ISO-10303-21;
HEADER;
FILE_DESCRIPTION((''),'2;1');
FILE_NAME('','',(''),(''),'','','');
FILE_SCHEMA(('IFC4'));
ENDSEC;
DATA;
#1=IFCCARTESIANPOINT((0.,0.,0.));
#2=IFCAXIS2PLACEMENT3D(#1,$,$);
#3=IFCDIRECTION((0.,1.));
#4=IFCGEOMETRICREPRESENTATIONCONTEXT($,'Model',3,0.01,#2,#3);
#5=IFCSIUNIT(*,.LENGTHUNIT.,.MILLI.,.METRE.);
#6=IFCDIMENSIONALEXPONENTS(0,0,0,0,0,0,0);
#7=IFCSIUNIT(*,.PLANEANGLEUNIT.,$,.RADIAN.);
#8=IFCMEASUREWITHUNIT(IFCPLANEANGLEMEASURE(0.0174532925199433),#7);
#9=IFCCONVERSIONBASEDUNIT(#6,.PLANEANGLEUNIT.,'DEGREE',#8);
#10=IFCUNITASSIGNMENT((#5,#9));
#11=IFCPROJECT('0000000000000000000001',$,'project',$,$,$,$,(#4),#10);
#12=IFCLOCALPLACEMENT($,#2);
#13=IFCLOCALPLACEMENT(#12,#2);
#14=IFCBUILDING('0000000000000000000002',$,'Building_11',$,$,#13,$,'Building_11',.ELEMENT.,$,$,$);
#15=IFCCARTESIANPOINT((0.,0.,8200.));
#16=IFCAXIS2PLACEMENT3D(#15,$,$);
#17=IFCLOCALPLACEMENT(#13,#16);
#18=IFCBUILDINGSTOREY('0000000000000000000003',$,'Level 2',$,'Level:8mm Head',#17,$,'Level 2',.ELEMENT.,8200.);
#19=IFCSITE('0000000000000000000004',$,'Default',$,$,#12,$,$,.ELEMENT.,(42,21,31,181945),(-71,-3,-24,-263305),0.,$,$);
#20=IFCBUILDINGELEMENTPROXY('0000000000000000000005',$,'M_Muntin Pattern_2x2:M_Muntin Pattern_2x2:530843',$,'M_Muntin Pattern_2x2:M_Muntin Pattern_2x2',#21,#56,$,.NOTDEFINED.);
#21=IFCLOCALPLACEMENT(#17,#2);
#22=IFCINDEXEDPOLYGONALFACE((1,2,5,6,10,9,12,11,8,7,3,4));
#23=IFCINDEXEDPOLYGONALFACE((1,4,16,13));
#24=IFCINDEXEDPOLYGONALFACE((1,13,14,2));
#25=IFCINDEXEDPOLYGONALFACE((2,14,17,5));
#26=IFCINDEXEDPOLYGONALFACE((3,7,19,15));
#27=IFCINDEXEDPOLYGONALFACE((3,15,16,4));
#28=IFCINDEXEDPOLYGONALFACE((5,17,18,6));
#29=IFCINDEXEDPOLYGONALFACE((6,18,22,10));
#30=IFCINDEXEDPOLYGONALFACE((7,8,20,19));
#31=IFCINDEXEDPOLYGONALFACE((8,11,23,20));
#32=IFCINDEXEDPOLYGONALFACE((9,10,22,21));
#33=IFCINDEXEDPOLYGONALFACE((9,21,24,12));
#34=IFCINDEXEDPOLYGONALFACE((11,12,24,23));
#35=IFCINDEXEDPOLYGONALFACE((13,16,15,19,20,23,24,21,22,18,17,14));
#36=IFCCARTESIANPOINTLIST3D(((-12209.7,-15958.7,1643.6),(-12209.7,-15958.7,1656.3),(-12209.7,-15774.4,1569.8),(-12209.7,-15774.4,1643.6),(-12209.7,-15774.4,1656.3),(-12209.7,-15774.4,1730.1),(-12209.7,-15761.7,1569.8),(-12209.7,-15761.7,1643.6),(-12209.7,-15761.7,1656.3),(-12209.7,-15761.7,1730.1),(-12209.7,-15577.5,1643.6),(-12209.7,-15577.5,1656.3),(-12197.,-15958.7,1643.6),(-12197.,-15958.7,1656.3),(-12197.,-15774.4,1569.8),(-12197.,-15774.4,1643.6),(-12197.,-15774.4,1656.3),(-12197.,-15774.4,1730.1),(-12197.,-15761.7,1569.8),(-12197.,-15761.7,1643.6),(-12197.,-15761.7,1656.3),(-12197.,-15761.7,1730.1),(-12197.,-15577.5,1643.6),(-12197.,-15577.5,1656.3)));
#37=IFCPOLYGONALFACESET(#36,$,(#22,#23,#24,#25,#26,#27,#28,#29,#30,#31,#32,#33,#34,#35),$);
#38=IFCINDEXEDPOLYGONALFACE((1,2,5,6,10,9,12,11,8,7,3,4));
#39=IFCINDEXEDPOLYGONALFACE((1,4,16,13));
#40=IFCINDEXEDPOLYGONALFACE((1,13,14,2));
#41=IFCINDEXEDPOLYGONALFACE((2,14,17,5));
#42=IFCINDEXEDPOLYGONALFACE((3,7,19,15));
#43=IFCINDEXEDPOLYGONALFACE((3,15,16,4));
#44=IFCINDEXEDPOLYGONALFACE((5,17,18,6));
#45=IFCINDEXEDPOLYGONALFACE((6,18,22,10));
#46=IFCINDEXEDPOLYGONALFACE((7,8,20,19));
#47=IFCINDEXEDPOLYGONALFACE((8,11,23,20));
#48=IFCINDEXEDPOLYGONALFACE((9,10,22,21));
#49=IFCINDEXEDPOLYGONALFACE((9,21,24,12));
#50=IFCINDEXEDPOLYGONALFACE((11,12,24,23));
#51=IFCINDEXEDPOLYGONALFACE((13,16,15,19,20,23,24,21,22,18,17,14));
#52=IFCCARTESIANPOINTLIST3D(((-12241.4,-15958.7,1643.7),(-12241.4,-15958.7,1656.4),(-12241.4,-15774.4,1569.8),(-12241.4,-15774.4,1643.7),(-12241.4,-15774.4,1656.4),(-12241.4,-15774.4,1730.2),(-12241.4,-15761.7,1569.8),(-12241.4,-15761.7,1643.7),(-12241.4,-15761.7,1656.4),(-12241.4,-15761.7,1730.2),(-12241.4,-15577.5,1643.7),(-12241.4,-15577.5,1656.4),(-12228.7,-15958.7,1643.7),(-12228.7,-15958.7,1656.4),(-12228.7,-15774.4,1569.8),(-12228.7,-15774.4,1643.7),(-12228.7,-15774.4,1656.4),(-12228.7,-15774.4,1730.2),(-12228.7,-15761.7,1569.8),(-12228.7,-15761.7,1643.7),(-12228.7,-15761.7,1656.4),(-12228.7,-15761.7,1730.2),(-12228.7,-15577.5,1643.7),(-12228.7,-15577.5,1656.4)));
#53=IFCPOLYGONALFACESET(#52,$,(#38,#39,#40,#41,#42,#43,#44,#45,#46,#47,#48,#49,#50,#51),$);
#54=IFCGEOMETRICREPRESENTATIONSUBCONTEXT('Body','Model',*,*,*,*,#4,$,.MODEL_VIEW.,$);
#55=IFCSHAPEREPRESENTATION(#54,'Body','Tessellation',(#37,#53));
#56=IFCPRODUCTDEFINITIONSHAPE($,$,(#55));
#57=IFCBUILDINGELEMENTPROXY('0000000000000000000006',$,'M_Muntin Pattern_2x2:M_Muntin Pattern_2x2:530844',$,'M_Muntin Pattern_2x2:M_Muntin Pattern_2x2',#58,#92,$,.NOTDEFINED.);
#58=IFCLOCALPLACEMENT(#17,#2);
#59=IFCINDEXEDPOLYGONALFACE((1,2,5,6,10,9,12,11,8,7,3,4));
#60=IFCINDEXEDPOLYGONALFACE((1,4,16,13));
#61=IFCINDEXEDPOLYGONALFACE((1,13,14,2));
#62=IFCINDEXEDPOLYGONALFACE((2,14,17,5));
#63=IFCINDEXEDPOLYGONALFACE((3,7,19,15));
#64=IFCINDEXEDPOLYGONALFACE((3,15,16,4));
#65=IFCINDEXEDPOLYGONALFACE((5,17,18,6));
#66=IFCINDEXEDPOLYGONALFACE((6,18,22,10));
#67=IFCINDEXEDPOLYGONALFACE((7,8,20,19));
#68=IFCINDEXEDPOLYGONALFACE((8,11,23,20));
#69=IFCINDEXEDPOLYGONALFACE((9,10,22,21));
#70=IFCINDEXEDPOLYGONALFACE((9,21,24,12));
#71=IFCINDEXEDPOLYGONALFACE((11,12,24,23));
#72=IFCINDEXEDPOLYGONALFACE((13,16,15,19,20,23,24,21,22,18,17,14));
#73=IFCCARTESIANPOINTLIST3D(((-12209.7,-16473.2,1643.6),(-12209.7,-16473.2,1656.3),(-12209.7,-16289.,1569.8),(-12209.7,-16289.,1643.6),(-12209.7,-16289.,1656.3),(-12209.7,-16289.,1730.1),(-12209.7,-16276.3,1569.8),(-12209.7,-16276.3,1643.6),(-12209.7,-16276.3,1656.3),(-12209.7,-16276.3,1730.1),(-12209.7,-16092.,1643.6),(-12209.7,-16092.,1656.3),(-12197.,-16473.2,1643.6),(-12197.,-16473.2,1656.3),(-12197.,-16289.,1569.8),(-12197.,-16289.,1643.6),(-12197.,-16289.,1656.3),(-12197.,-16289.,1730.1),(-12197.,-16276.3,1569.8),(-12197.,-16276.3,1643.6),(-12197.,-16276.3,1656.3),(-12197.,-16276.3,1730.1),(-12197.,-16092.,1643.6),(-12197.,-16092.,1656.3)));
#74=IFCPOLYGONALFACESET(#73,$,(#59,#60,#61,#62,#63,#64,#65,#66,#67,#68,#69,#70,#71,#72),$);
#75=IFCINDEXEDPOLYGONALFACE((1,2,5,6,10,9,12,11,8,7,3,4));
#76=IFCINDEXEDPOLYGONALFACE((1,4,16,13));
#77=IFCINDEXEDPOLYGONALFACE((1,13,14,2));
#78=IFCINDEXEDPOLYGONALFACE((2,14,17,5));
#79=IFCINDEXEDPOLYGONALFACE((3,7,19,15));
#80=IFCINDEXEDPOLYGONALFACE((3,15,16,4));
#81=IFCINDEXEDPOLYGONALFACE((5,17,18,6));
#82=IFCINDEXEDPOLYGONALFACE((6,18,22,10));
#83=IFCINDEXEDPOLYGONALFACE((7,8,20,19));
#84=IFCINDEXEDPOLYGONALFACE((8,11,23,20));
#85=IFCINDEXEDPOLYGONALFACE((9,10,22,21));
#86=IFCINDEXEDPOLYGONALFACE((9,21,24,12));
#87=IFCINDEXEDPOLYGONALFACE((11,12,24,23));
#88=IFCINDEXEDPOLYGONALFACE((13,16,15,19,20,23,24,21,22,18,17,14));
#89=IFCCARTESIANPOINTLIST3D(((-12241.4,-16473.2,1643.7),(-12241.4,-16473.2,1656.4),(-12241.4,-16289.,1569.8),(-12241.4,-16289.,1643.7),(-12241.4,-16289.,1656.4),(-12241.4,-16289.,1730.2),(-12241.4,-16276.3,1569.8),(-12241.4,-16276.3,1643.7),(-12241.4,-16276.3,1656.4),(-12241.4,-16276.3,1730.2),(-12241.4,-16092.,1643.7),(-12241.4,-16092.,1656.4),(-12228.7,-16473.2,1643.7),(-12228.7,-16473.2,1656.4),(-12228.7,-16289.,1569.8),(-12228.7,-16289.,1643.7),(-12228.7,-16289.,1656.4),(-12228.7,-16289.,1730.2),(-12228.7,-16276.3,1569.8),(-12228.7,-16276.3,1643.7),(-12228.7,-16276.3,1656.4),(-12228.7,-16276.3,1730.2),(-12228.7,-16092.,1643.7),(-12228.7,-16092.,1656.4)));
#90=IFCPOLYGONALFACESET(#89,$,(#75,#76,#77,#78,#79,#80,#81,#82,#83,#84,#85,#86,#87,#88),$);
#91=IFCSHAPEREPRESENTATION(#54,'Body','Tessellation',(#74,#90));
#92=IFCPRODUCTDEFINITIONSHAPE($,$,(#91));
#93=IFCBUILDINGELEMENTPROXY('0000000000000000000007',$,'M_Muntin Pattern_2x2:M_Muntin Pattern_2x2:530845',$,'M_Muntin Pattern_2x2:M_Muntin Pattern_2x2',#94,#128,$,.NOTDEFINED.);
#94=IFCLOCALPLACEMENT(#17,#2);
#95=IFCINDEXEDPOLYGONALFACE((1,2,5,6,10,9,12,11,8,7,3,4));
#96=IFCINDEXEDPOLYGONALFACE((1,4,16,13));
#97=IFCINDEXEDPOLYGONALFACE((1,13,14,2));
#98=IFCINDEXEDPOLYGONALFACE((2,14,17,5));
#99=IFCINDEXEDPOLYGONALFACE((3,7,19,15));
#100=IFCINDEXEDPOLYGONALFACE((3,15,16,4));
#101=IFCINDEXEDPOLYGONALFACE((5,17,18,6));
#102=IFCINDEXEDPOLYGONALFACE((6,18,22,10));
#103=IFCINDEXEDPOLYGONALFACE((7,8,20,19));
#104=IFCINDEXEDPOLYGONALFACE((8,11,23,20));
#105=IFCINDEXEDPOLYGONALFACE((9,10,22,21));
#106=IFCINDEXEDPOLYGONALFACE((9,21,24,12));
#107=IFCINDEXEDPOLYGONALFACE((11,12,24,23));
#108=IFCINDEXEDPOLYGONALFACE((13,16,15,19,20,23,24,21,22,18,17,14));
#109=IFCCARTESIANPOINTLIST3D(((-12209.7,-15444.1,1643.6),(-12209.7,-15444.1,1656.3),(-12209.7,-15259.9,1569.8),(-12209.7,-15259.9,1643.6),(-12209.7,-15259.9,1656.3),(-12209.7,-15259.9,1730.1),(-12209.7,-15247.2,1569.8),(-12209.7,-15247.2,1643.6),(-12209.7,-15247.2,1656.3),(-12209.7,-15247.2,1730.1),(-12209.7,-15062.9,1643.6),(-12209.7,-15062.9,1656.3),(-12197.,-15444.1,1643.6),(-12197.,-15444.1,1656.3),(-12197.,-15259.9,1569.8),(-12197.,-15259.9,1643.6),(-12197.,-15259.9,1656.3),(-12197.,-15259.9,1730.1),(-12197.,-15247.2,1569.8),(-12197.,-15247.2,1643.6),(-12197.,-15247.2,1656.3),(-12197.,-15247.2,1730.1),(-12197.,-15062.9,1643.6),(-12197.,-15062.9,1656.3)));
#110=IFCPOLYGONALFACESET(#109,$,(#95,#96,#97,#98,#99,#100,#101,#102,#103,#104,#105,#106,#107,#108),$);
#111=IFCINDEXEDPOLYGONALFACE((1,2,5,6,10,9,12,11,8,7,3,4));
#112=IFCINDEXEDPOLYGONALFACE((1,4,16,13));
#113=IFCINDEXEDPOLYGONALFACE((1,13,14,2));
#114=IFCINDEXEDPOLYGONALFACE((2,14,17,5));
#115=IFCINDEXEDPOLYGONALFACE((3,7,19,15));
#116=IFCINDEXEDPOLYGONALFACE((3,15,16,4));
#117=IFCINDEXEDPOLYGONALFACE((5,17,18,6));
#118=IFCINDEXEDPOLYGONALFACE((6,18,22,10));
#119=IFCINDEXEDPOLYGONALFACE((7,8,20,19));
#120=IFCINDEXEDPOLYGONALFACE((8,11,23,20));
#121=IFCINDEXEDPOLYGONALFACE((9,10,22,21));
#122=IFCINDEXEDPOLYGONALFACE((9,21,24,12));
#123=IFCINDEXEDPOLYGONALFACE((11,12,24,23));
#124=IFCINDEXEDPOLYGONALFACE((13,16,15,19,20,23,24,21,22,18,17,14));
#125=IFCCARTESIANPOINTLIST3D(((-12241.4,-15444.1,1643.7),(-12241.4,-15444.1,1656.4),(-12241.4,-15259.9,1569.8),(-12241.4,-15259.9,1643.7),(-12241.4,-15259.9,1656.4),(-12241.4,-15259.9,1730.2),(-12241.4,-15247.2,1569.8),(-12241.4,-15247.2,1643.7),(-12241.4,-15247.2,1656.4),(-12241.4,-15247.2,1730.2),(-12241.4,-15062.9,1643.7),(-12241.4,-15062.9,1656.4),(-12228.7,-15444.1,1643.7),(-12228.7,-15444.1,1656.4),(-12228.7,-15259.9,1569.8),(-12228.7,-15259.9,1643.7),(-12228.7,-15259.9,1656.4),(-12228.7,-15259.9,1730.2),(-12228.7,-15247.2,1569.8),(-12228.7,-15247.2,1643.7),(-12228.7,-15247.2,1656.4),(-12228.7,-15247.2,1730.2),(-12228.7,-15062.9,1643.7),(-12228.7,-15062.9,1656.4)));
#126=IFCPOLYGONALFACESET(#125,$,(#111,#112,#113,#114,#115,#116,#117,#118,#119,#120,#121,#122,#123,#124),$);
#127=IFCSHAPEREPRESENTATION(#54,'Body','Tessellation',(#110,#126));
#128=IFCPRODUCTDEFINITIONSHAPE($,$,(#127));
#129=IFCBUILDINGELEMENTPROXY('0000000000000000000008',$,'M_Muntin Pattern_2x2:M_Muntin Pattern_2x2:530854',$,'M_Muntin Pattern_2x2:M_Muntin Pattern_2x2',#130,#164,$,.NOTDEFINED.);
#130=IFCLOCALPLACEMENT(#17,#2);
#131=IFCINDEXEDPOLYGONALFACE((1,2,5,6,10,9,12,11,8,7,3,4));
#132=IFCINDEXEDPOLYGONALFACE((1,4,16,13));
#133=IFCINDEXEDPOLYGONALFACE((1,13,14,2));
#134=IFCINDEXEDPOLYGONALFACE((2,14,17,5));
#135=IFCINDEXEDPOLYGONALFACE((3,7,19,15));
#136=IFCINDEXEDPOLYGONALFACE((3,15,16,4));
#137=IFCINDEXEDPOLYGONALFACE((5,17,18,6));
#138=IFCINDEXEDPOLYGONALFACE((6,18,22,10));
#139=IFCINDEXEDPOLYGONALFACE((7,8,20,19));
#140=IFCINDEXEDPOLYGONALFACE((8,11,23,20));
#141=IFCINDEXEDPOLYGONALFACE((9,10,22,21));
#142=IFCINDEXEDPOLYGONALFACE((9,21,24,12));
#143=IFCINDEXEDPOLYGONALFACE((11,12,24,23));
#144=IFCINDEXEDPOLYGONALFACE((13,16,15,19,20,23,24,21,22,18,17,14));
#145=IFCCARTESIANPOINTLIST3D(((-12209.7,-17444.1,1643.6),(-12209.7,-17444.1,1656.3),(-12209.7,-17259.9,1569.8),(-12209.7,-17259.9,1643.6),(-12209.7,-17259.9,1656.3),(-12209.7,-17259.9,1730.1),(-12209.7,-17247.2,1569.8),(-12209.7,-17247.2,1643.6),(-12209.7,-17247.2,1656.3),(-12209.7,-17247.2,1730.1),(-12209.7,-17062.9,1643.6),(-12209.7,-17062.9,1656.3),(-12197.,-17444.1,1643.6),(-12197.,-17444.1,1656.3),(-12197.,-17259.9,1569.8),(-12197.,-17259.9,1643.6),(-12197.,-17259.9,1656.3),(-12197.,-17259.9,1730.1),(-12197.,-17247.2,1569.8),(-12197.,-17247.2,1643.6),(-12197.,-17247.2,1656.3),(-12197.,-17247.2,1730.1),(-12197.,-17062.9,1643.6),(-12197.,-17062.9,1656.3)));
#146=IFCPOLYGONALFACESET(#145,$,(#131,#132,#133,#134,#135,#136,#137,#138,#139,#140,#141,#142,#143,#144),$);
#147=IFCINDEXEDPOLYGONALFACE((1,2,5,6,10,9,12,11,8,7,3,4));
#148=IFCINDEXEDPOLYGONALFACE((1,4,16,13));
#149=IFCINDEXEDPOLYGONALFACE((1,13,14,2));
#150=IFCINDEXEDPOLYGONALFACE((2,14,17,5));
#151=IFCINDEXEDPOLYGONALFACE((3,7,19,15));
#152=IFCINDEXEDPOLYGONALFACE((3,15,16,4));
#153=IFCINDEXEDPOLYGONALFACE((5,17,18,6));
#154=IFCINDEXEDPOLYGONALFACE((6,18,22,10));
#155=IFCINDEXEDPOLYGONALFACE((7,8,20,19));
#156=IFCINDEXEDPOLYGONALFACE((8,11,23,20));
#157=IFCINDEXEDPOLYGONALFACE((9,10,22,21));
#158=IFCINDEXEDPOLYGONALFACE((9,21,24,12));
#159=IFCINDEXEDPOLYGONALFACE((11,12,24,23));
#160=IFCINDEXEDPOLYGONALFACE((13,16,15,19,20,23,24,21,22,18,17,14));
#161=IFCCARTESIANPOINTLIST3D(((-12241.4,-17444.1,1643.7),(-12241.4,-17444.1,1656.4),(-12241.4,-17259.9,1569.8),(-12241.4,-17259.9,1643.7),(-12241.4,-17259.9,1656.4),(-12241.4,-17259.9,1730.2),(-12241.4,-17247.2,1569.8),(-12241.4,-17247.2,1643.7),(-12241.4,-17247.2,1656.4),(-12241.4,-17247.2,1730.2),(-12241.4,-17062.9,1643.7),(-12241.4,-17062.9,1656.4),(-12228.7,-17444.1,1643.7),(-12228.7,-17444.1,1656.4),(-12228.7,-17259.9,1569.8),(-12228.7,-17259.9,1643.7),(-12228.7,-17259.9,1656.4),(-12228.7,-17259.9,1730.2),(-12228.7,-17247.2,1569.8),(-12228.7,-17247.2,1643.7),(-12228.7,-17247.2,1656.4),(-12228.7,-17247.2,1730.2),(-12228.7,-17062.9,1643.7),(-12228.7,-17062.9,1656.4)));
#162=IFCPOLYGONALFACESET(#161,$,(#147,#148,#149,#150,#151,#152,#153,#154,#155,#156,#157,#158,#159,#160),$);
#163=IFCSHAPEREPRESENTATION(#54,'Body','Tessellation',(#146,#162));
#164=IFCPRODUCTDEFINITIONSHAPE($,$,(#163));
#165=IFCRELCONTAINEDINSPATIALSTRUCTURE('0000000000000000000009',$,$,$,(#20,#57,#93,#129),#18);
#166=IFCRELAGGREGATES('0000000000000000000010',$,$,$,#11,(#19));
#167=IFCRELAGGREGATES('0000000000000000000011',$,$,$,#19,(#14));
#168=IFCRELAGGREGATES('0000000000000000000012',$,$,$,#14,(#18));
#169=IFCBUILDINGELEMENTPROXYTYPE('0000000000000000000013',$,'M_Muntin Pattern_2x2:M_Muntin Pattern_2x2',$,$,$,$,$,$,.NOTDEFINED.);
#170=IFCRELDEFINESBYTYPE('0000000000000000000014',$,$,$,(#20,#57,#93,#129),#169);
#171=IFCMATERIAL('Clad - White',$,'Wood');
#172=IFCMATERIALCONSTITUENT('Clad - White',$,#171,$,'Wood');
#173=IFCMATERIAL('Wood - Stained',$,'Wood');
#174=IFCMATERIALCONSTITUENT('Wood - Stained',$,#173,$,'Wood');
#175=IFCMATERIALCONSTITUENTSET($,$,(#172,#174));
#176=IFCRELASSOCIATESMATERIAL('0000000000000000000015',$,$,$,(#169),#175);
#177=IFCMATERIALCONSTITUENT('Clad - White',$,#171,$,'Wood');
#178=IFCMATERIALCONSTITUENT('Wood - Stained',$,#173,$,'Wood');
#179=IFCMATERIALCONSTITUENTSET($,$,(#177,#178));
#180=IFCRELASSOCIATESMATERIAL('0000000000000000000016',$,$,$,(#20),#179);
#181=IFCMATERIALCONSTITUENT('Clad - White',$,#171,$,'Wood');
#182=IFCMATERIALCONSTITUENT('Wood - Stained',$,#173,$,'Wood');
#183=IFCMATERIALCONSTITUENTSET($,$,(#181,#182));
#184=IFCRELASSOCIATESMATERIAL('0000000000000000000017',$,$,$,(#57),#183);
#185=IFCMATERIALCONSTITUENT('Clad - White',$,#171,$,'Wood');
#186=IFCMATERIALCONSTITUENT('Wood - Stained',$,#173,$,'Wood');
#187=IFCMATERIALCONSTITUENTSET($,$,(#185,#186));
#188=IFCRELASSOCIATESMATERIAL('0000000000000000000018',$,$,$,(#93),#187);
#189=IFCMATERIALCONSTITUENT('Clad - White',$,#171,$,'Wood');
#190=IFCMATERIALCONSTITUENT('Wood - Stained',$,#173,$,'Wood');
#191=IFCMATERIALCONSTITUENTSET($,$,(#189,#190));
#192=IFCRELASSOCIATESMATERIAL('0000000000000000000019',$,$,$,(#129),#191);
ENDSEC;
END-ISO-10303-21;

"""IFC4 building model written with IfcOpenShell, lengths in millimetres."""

from ifc_helpers import new_model, entity, si_unit, converted_unit, direction, frame, origin, place, context, subcontext, project, spatial, indexed_curve, outline, extrude, source, transform, mapped, material, constituent, constituent_set, type_object, type_shapes, element, save


model = new_model("IFC4")

# Units and contexts
model_context = context("Model", 3, precision=0.01, world=origin(), true_north=direction((0.0, 1.0)))
body_context = subcontext(model_context, "Body", "Model", "MODEL_VIEW")
ifc_project = project(units=[si_unit("LENGTHUNIT", "METRE", prefix="MILLI"), converted_unit("PLANEANGLEUNIT", "DEGREE", entity("IfcPlaneAngleMeasure", 0.0174532925199433), si_unit("PLANEANGLEUNIT", "RADIAN"), dimensions=[0, 0, 0, 0, 0, 0, 0])], contexts=[model_context])

# Site, building, storey
site_placement = place(None, origin())
site = spatial("IfcSite", under=ifc_project, at=site_placement, Name="Default", CompositionType="ELEMENT", RefLatitude=(42, 21, 31, 181945), RefLongitude=(-71, -3, -24, -263305), RefElevation=0.0)
building_placement = place(site_placement, origin())
building = spatial("IfcBuilding", under=site, at=building_placement, Name="Building_11", LongName="Building_11", CompositionType="ELEMENT")
storey_placement = place(building_placement, frame((0.0, 0.0, 8200.0)))
storey = spatial("IfcBuildingStorey", under=building, at=storey_placement, Name="Level 2", ObjectType="Level:8mm Head", LongName="Level 2", CompositionType="ELEMENT", Elevation=8200.0)

# Building element proxies
ifc_material_1 = material(Name="Clad - White", Category="Wood")
ifc_material_2 = material(Name="Wood - Stained", Category="Wood")
ifc_constituent_1 = constituent(ifc_material_1, Name="Clad - White", Category="Wood")
ifc_constituent_2 = constituent(ifc_material_2, Name="Wood - Stained", Category="Wood")
ifc_constituent_set_1 = constituent_set(constituents=[ifc_constituent_1, ifc_constituent_2])
building_element_proxy_type_1 = type_object("IfcBuildingElementProxyType", Name="M_Muntin Pattern_2x2:M_Muntin Pattern_2x2", PredefinedType="NOTDEFINED", material=ifc_constituent_set_1)
shared_shape_1 = source(origin(), body_context, "Body", "SweptSolid", [
    extrude(outline(indexed_curve([(6.4, -6.4), (80.1, -6.4), (80.1, 6.3), (6.4, 6.3), (6.4, 190.6), (-6.3, 190.6), (-6.3, 6.3), (-80.2, 6.3), (-80.2, -6.4), (-6.3, -6.4), (-6.3, -190.6), (6.4, -190.6), (6.4, -6.4)], self_intersect=False)), frame((0.0, 9.5, 80.1), z_axis=(0.0, 1.0, 0.0), x_axis=(0.0, 0.0, 1.0)), (0.0, 0.0, 1.0), 12.7),
    extrude(outline(indexed_curve([(6.4, -6.4), (80.2, -6.4), (80.2, 6.3), (6.4, 6.3), (6.4, 190.6), (-6.3, 190.6), (-6.3, 6.3), (-80.2, 6.3), (-80.2, -6.4), (-6.3, -6.4), (-6.3, -190.6), (6.4, -190.6), (6.4, -6.4)], self_intersect=False)), frame((0.0, -22.2, 80.2), z_axis=(0.0, 1.0, 0.0), x_axis=(0.0, 0.0, 1.0)), (0.0, 0.0, 1.0), 12.7),
])
type_shapes(building_element_proxy_type_1, [shared_shape_1])
ifc_constituent_3 = constituent(ifc_material_1, Name="Clad - White", Category="Wood")
ifc_constituent_4 = constituent(ifc_material_2, Name="Wood - Stained", Category="Wood")
ifc_constituent_set_2 = constituent_set(constituents=[ifc_constituent_3, ifc_constituent_4])
proxy_1_placement = place(storey_placement, frame((-12219.2, -15768.1, 1569.8), z_axis=(0.0, 0.0, 1.0), x_axis=(0.0, -1.0, 0.0)))
element("IfcBuildingElementProxy", 1, at=proxy_1_placement, inside=storey, type_object=building_element_proxy_type_1, material=ifc_constituent_set_2, Name="M_Muntin Pattern_2x2:M_Muntin Pattern_2x2:530843", ObjectType="M_Muntin Pattern_2x2:M_Muntin Pattern_2x2", PredefinedType="NOTDEFINED", context=body_context, shape_type="MappedRepresentation", body=[
    mapped(shared_shape_1, transform((0.0, 0.0, 0.0), scale=1.0)),
])
ifc_constituent_5 = constituent(ifc_material_1, Name="Clad - White", Category="Wood")
ifc_constituent_6 = constituent(ifc_material_2, Name="Wood - Stained", Category="Wood")
ifc_constituent_set_3 = constituent_set(constituents=[ifc_constituent_5, ifc_constituent_6])
proxy_2_placement = place(storey_placement, frame((-12219.2, -16282.6, 1569.8), z_axis=(0.0, 0.0, 1.0), x_axis=(0.0, -1.0, 0.0)))
element("IfcBuildingElementProxy", 2, at=proxy_2_placement, inside=storey, type_object=building_element_proxy_type_1, material=ifc_constituent_set_3, Name="M_Muntin Pattern_2x2:M_Muntin Pattern_2x2:530844", ObjectType="M_Muntin Pattern_2x2:M_Muntin Pattern_2x2", PredefinedType="NOTDEFINED", context=body_context, shape_type="MappedRepresentation", body=[
    mapped(shared_shape_1, transform((0.0, 0.0, 0.0), scale=1.0)),
])
ifc_constituent_7 = constituent(ifc_material_1, Name="Clad - White", Category="Wood")
ifc_constituent_8 = constituent(ifc_material_2, Name="Wood - Stained", Category="Wood")
ifc_constituent_set_4 = constituent_set(constituents=[ifc_constituent_7, ifc_constituent_8])
proxy_3_placement = place(storey_placement, frame((-12219.2, -15253.5, 1569.8), z_axis=(0.0, 0.0, 1.0), x_axis=(0.0, -1.0, 0.0)))
element("IfcBuildingElementProxy", 3, at=proxy_3_placement, inside=storey, type_object=building_element_proxy_type_1, material=ifc_constituent_set_4, Name="M_Muntin Pattern_2x2:M_Muntin Pattern_2x2:530845", ObjectType="M_Muntin Pattern_2x2:M_Muntin Pattern_2x2", PredefinedType="NOTDEFINED", context=body_context, shape_type="MappedRepresentation", body=[
    mapped(shared_shape_1, transform((0.0, 0.0, 0.0), scale=1.0)),
])
ifc_constituent_9 = constituent(ifc_material_1, Name="Clad - White", Category="Wood")
ifc_constituent_10 = constituent(ifc_material_2, Name="Wood - Stained", Category="Wood")
ifc_constituent_set_5 = constituent_set(constituents=[ifc_constituent_9, ifc_constituent_10])
proxy_4_placement = place(storey_placement, frame((-12219.2, -17253.5, 1569.8), z_axis=(0.0, 0.0, 1.0), x_axis=(0.0, -1.0, 0.0)))
element("IfcBuildingElementProxy", 4, at=proxy_4_placement, inside=storey, type_object=building_element_proxy_type_1, material=ifc_constituent_set_5, Name="M_Muntin Pattern_2x2:M_Muntin Pattern_2x2:530854", ObjectType="M_Muntin Pattern_2x2:M_Muntin Pattern_2x2", PredefinedType="NOTDEFINED", context=body_context, shape_type="MappedRepresentation", body=[
    mapped(shared_shape_1, transform((0.0, 0.0, 0.0), scale=1.0)),
])

save(model, "model.ifc")
